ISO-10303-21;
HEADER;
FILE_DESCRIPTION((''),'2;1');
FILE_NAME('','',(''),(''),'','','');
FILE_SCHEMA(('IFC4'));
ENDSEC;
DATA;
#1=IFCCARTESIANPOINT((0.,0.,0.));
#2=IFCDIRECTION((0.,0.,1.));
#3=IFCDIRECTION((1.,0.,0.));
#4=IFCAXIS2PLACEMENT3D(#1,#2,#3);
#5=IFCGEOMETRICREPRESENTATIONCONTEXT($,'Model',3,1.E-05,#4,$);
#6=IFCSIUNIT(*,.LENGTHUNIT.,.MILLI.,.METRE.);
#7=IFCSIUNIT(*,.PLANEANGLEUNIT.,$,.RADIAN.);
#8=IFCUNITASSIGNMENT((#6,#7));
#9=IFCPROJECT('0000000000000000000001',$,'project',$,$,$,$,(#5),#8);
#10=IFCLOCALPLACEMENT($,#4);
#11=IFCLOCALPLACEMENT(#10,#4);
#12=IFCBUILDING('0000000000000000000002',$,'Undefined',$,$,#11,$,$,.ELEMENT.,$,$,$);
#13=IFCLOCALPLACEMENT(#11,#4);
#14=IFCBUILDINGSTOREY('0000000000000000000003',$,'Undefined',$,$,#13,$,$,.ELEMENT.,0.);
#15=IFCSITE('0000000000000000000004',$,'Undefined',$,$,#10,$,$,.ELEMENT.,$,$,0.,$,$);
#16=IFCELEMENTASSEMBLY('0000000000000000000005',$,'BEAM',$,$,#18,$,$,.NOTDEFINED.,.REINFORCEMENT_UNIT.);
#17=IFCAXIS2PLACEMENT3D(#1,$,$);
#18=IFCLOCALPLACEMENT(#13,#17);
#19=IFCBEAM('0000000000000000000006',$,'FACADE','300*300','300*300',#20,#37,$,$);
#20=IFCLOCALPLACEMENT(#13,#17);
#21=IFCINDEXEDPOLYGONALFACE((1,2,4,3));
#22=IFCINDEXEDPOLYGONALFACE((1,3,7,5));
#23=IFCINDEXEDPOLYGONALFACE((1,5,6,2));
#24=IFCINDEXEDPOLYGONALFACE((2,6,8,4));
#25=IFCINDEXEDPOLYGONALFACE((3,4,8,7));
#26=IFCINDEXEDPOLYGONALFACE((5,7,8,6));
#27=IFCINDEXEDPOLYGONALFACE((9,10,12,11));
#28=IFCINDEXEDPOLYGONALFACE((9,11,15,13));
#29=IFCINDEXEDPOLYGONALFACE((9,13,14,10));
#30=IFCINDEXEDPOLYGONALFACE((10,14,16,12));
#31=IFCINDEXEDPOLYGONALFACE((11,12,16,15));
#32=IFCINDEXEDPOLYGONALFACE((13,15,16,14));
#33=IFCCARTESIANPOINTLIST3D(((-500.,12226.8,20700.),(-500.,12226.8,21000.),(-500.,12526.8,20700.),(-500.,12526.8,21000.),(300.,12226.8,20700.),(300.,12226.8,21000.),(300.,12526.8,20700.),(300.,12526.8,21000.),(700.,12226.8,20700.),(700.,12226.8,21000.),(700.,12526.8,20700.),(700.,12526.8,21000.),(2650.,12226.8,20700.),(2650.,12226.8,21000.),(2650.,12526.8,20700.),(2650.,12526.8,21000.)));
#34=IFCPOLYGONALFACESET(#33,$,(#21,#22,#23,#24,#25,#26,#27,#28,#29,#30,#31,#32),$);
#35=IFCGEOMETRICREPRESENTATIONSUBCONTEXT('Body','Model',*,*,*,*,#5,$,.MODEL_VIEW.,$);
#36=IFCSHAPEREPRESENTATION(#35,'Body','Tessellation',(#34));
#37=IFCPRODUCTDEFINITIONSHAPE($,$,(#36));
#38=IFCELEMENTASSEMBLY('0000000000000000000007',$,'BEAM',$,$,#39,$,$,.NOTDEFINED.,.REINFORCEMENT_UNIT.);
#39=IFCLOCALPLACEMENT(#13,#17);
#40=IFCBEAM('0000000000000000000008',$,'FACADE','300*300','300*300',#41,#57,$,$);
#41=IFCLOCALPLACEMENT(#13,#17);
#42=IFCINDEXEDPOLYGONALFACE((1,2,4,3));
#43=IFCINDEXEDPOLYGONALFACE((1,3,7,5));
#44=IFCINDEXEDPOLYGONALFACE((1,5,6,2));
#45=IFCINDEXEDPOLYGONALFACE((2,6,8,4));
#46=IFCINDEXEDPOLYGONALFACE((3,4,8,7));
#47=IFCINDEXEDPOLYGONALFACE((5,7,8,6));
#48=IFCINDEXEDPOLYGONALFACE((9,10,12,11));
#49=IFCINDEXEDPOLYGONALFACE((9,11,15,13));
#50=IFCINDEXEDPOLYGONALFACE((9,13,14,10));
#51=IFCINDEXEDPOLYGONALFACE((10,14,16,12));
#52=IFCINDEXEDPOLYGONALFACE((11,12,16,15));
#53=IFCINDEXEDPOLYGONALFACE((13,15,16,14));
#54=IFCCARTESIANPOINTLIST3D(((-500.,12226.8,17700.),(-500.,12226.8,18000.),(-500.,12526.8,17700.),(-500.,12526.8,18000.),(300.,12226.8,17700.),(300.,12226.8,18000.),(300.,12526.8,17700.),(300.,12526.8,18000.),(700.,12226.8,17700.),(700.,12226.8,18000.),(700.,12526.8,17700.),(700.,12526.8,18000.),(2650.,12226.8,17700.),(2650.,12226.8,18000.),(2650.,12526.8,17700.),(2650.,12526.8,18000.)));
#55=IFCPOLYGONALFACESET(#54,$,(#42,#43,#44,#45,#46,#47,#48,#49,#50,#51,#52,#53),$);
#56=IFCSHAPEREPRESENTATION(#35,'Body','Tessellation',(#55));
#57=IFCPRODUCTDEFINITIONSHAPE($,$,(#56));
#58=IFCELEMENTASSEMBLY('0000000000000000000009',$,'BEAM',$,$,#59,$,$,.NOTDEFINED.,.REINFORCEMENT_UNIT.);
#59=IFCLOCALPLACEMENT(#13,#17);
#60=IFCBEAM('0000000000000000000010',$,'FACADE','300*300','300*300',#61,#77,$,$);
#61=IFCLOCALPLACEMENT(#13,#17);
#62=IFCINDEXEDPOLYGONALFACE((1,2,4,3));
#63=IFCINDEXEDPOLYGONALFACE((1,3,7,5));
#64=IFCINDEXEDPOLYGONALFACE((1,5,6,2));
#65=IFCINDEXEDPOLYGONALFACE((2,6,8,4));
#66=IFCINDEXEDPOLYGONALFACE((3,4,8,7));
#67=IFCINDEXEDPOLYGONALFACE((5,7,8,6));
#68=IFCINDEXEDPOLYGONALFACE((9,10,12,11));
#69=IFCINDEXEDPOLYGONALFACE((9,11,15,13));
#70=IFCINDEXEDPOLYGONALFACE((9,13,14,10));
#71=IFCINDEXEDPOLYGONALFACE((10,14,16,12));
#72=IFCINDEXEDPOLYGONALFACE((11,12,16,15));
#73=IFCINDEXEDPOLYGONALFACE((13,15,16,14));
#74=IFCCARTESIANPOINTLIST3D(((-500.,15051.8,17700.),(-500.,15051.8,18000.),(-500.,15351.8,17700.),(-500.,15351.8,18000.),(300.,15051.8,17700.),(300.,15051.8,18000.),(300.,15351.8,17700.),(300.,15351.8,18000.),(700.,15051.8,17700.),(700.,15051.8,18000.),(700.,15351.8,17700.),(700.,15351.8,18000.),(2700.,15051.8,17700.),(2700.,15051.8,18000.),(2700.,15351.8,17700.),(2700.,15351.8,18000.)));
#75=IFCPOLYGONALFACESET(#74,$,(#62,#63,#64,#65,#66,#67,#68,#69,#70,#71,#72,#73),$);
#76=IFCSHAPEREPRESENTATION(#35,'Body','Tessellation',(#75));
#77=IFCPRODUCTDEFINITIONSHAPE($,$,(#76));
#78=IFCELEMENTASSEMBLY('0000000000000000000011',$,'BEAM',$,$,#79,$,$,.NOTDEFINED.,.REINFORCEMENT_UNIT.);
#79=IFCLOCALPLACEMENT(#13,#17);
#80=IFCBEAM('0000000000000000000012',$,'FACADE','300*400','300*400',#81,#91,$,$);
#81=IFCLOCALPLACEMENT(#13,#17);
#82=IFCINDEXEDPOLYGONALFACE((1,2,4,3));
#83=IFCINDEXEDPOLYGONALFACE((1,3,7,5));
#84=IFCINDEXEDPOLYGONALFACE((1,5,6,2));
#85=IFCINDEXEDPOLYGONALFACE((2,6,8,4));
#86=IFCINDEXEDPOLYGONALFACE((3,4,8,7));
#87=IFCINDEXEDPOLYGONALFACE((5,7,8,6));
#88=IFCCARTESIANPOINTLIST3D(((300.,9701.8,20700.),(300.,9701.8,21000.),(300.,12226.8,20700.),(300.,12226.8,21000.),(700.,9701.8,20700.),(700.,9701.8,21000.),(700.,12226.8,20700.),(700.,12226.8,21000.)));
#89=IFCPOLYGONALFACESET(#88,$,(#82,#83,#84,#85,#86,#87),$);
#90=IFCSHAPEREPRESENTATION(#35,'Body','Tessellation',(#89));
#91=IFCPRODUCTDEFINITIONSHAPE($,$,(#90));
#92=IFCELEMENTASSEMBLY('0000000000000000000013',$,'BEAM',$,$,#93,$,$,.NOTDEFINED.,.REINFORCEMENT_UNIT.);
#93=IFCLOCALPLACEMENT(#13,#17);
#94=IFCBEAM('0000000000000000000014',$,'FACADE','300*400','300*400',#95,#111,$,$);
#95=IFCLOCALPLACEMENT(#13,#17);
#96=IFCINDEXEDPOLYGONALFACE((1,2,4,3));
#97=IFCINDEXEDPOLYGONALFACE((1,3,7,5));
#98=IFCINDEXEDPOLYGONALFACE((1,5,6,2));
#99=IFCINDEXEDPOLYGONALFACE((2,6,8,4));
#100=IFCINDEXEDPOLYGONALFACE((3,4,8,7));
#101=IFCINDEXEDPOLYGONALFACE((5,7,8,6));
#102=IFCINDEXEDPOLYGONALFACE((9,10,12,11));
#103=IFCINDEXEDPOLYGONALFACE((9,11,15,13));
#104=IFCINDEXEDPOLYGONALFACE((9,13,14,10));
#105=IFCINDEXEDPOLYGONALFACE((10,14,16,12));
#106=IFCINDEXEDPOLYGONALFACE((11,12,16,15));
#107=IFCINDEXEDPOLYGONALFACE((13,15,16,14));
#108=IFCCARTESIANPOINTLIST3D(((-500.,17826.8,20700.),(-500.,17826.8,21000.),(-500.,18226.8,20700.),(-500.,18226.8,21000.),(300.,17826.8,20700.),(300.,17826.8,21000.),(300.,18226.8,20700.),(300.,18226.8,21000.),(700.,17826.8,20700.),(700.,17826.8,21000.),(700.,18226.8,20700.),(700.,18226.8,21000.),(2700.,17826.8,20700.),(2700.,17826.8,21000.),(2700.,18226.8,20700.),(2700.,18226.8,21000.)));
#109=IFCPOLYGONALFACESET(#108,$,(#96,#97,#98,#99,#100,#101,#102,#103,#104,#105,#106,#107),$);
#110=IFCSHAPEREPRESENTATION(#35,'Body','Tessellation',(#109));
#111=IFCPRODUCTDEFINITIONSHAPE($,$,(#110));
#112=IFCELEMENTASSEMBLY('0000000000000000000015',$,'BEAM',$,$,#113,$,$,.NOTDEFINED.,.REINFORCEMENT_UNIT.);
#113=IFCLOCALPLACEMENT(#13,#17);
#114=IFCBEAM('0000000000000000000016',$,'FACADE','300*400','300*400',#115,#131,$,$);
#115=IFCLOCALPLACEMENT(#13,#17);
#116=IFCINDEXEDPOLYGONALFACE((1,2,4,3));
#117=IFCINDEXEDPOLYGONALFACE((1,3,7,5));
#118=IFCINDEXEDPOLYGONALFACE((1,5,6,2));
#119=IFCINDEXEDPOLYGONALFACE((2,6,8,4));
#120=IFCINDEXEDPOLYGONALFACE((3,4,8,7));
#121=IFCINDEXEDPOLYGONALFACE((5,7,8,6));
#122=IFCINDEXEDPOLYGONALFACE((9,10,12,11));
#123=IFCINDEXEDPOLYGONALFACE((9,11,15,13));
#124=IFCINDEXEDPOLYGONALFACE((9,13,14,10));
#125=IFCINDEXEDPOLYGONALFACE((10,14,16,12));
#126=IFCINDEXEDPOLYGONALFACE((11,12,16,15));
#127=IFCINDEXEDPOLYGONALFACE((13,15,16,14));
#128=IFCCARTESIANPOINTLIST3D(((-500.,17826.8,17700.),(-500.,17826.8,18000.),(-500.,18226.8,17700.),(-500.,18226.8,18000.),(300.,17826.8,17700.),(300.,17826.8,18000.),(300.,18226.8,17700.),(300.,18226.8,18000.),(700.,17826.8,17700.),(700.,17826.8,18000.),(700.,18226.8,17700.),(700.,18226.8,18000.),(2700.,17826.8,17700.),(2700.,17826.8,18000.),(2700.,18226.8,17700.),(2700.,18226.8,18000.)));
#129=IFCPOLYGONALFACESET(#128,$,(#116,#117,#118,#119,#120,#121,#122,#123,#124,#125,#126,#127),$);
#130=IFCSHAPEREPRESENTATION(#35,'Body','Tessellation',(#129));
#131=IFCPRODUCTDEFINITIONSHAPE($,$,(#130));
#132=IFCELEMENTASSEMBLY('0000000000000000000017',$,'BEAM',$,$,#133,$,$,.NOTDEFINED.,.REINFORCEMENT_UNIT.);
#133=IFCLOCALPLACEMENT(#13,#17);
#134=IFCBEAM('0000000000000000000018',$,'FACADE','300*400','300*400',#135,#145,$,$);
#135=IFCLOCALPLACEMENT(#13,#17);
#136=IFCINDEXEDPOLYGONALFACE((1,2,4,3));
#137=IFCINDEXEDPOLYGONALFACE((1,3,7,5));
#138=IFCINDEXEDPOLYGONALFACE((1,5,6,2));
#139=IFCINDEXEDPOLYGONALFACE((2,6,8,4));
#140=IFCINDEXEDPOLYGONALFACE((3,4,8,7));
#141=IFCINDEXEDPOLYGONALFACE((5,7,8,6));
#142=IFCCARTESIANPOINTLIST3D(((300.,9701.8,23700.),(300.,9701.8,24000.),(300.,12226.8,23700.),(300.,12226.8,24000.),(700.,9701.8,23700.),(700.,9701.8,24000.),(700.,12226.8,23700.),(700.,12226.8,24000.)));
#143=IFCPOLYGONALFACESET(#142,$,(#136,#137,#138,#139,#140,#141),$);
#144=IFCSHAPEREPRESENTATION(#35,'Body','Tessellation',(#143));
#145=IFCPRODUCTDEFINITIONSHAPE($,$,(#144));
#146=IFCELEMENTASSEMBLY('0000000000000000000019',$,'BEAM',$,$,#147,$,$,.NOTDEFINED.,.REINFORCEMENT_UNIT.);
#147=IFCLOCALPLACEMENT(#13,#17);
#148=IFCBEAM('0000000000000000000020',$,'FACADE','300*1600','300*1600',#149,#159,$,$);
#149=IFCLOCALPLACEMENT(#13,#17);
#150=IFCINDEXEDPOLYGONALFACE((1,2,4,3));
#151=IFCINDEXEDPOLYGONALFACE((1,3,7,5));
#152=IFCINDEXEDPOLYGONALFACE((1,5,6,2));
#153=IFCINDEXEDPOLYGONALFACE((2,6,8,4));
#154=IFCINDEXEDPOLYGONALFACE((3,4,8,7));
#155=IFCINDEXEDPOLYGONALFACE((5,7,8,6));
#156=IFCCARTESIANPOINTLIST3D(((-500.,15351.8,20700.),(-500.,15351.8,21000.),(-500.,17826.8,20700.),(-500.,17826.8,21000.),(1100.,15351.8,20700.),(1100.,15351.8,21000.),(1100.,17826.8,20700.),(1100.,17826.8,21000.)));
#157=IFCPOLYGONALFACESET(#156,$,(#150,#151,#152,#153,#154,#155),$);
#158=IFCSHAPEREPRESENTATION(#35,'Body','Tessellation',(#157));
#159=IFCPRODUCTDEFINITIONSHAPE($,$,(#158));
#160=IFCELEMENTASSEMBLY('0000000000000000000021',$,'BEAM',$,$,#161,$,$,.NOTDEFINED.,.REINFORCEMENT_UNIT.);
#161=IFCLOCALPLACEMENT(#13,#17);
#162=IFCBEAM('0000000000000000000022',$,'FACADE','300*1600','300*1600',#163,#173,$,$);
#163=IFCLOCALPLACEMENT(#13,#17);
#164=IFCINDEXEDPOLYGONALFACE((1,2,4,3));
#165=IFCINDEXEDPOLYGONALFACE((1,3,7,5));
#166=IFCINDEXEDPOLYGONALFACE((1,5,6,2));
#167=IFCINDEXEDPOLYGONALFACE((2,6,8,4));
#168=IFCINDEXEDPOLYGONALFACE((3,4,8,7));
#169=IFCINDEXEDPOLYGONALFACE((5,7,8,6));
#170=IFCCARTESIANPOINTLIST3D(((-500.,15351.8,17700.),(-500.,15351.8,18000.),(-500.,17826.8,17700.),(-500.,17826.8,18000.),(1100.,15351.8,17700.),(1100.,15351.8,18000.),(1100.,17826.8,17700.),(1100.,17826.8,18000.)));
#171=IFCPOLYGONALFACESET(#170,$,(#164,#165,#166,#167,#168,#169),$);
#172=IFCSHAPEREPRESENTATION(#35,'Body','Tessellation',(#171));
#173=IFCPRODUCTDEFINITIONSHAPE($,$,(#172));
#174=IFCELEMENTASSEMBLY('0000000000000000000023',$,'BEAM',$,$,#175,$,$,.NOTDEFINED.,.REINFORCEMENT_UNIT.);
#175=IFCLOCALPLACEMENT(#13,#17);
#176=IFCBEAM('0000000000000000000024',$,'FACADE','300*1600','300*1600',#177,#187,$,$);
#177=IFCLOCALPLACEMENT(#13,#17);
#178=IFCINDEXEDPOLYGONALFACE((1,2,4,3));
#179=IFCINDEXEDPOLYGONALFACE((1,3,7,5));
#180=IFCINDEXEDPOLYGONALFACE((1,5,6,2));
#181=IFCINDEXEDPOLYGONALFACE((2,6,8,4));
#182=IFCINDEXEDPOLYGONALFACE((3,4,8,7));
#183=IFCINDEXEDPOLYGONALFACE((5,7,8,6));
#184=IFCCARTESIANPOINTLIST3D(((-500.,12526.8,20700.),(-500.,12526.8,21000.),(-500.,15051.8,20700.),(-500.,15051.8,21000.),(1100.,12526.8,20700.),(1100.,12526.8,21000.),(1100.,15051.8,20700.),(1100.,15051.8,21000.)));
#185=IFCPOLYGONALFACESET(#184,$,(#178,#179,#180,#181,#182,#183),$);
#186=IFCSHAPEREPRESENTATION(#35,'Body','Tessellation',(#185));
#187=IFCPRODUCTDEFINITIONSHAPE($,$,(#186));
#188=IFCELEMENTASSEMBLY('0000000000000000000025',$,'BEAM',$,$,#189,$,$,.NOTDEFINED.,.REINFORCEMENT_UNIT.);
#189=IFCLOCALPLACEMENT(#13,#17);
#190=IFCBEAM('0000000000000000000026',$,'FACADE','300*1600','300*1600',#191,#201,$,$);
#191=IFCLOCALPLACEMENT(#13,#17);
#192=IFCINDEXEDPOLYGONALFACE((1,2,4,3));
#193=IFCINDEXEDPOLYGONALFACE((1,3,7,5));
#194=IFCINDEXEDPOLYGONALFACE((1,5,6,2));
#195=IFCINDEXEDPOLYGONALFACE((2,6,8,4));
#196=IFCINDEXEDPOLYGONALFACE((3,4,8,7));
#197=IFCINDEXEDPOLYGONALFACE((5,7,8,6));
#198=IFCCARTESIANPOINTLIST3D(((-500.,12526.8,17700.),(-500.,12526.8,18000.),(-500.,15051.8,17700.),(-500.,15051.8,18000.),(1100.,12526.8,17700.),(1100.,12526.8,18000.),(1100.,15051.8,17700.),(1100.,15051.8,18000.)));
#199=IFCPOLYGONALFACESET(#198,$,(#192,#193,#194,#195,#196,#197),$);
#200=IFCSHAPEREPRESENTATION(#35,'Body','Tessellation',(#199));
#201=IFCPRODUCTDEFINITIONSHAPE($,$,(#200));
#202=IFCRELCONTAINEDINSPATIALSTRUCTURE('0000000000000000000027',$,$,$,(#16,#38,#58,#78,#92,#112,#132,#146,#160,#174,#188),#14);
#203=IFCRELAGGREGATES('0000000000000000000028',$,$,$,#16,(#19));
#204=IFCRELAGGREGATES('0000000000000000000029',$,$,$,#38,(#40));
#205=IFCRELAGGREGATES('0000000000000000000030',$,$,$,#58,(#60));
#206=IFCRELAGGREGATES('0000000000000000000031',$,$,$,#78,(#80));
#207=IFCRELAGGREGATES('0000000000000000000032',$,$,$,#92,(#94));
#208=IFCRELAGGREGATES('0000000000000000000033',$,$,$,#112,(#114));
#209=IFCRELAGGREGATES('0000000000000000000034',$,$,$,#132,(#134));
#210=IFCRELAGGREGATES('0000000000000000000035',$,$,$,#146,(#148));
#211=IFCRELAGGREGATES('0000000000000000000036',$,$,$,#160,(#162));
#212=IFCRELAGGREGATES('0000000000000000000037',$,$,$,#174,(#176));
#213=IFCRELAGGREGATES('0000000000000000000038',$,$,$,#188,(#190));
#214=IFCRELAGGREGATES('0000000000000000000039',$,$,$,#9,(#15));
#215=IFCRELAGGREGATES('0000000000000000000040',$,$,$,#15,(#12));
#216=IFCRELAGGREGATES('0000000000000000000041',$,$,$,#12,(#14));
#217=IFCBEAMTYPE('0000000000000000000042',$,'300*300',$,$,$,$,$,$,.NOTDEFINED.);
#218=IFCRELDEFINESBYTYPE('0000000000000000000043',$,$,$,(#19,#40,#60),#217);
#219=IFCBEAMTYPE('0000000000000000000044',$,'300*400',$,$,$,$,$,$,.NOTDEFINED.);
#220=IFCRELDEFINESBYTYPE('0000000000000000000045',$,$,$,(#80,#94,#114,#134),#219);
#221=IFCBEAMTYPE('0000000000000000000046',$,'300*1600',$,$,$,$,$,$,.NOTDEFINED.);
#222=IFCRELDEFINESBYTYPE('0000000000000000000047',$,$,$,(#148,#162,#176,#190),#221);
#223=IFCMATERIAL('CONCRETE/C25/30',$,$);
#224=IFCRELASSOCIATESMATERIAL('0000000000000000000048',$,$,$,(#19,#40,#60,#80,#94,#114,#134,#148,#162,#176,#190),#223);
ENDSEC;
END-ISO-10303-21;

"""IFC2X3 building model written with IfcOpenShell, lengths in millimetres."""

from ifc_helpers import new_model, si_unit, frame, origin_with_axes, origin_2d_with_axis, place, context, subcontext, project, spatial, rectangle, extrude, boolean, material, type_object, element, aggregate, save


model = new_model("IFC2X3")

# Units and contexts
model_context = context("Model", 3, precision=1e-05, world=origin_with_axes())
body_context = subcontext(model_context, "Body", "Model", "MODEL_VIEW")
ifc_project = project(units=[si_unit("LENGTHUNIT", "METRE", prefix="MILLI"), si_unit("PLANEANGLEUNIT", "RADIAN")], contexts=[model_context])

# Site, building, storey
site_placement = place(None, origin_with_axes())
site = spatial("IfcSite", under=ifc_project, at=site_placement, Name="Undefined", CompositionType="ELEMENT", RefElevation=0.0)
building_placement = place(site_placement, origin_with_axes())
building = spatial("IfcBuilding", under=site, at=building_placement, Name="Undefined", CompositionType="ELEMENT")
storey_placement = place(building_placement, origin_with_axes())
storey = spatial("IfcBuildingStorey", under=building, at=storey_placement, Name="Undefined", CompositionType="ELEMENT", Elevation=0.0)

# Shared definitions
ifc_material = material(Name="CONCRETE/C25/30")

# Element assemblies, beams
beam_type_1 = type_object("IfcBeamType", Name="300*300", PredefinedType="NOTDEFINED")
assembly_1_placement = place(storey_placement, origin_with_axes())
assembly_1 = element("IfcElementAssembly", 1, at=assembly_1_placement, inside=storey, Name="BEAM", AssemblyPlace="NOTDEFINED", PredefinedType="REINFORCEMENT_UNIT")
beam_1_placement = place(assembly_1_placement, frame((2650.0, 12376.8, 20850.0), z_axis=(0.0, 0.0, 1.0), x_axis=(-1.0, 0.0, 0.0)))
beam_1 = element("IfcBeam", 2, at=beam_1_placement, type_object=beam_type_1, material=ifc_material, Name="FACADE", Description="300*300", ObjectType="300*300", context=body_context, shape_type="CSG", body=[
    boolean("DIFFERENCE", extrude(rectangle(XDim=300.0, YDim=300.0, at=origin_2d_with_axis()), frame((3150.0, 0.0, 0.0), z_axis=(-1.0, 0.0, 0.0), x_axis=(0.0, -1.0, 0.0)), (0.0, 0.0, 1.0), 3150.0), extrude(rectangle(XDim=400.0, YDim=300.0, at=origin_2d_with_axis()), frame((2150.0, 0.0, 150.0), z_axis=(0.0, 0.0, -1.0), x_axis=(1.0, 0.0, 0.0)), (0.0, 0.0, 1.0), 3000.0)),
])
aggregate(assembly_1, [beam_1])
assembly_2_placement = place(storey_placement, origin_with_axes())
assembly_2 = element("IfcElementAssembly", 3, at=assembly_2_placement, inside=storey, Name="BEAM", AssemblyPlace="NOTDEFINED", PredefinedType="REINFORCEMENT_UNIT")
beam_2_placement = place(assembly_2_placement, frame((2650.0, 12376.8, 17850.0), z_axis=(0.0, 0.0, 1.0), x_axis=(-1.0, 0.0, 0.0)))
beam_2 = element("IfcBeam", 4, at=beam_2_placement, type_object=beam_type_1, material=ifc_material, Name="FACADE", Description="300*300", ObjectType="300*300", context=body_context, shape_type="CSG", body=[
    boolean("DIFFERENCE", extrude(rectangle(XDim=300.0, YDim=300.0, at=origin_2d_with_axis()), frame((3150.0, 0.0, 0.0), z_axis=(-1.0, 0.0, 0.0), x_axis=(0.0, -1.0, 0.0)), (0.0, 0.0, 1.0), 3150.0), extrude(rectangle(XDim=400.0, YDim=300.0, at=origin_2d_with_axis()), frame((2150.0, 0.0, 150.0), z_axis=(0.0, 0.0, -1.0), x_axis=(1.0, 0.0, 0.0)), (0.0, 0.0, 1.0), 3000.0)),
])
aggregate(assembly_2, [beam_2])
assembly_3_placement = place(storey_placement, origin_with_axes())
assembly_3 = element("IfcElementAssembly", 5, at=assembly_3_placement, inside=storey, Name="BEAM", AssemblyPlace="NOTDEFINED", PredefinedType="REINFORCEMENT_UNIT")
beam_3_placement = place(assembly_3_placement, frame((2700.0, 15201.8, 17850.0), z_axis=(0.0, 0.0, 1.0), x_axis=(-1.0, 0.0, 0.0)))
beam_3 = element("IfcBeam", 6, at=beam_3_placement, type_object=beam_type_1, material=ifc_material, Name="FACADE", Description="300*300", ObjectType="300*300", context=body_context, shape_type="CSG", body=[
    boolean("DIFFERENCE", extrude(rectangle(XDim=300.0, YDim=300.0, at=origin_2d_with_axis()), frame((3200.0, 0.0, 0.0), z_axis=(-1.0, 0.0, 0.0), x_axis=(0.0, -1.0, 0.0)), (0.0, 0.0, 1.0), 3200.0), extrude(rectangle(XDim=400.0, YDim=300.0, at=origin_2d_with_axis()), frame((2200.0, 0.0, 150.0), z_axis=(0.0, 0.0, -1.0), x_axis=(1.0, 0.0, 0.0)), (0.0, 0.0, 1.0), 3000.0)),
])
aggregate(assembly_3, [beam_3])
beam_type_2 = type_object("IfcBeamType", Name="300*400", PredefinedType="NOTDEFINED")
assembly_4_placement = place(storey_placement, origin_with_axes())
assembly_4 = element("IfcElementAssembly", 7, at=assembly_4_placement, inside=storey, Name="BEAM", AssemblyPlace="NOTDEFINED", PredefinedType="REINFORCEMENT_UNIT")
beam_4_placement = place(assembly_4_placement, frame((500.0, 12226.8, 20850.0), z_axis=(0.0, 0.0, 1.0), x_axis=(0.0, -1.0, 0.0)))
beam_4 = element("IfcBeam", 8, at=beam_4_placement, type_object=beam_type_2, material=ifc_material, Name="FACADE", Description="300*400", ObjectType="300*400", context=body_context, shape_type="SweptSolid", body=[
    extrude(rectangle(XDim=400.0, YDim=300.0, at=origin_2d_with_axis()), frame((2525.0, 0.0, 0.0), z_axis=(-1.0, 0.0, 0.0), x_axis=(0.0, -1.0, 0.0)), (0.0, 0.0, 1.0), 2525.0),
])
aggregate(assembly_4, [beam_4])
assembly_5_placement = place(storey_placement, origin_with_axes())
assembly_5 = element("IfcElementAssembly", 9, at=assembly_5_placement, inside=storey, Name="BEAM", AssemblyPlace="NOTDEFINED", PredefinedType="REINFORCEMENT_UNIT")
beam_5_placement = place(assembly_5_placement, frame((2700.0, 18026.8, 20850.0), z_axis=(0.0, 0.0, 1.0), x_axis=(-1.0, 0.0, 0.0)))
beam_5 = element("IfcBeam", 10, at=beam_5_placement, type_object=beam_type_2, material=ifc_material, Name="FACADE", Description="300*400", ObjectType="300*400", context=body_context, shape_type="CSG", body=[
    boolean("DIFFERENCE", extrude(rectangle(XDim=400.0, YDim=300.0, at=origin_2d_with_axis()), frame((3200.0, 0.0, 0.0), z_axis=(-1.0, 0.0, 0.0), x_axis=(0.0, -1.0, 0.0)), (0.0, 0.0, 1.0), 3200.0), extrude(rectangle(XDim=400.0, YDim=400.0, at=origin_2d_with_axis()), frame((2200.0, 0.0, 150.0), z_axis=(0.0, 0.0, -1.0), x_axis=(1.0, 0.0, 0.0)), (0.0, 0.0, 1.0), 3000.0)),
])
aggregate(assembly_5, [beam_5])
assembly_6_placement = place(storey_placement, origin_with_axes())
assembly_6 = element("IfcElementAssembly", 11, at=assembly_6_placement, inside=storey, Name="BEAM", AssemblyPlace="NOTDEFINED", PredefinedType="REINFORCEMENT_UNIT")
beam_6_placement = place(assembly_6_placement, frame((2700.0, 18026.8, 17850.0), z_axis=(0.0, 0.0, 1.0), x_axis=(-1.0, 0.0, 0.0)))
beam_6 = element("IfcBeam", 12, at=beam_6_placement, type_object=beam_type_2, material=ifc_material, Name="FACADE", Description="300*400", ObjectType="300*400", context=body_context, shape_type="CSG", body=[
    boolean("DIFFERENCE", extrude(rectangle(XDim=400.0, YDim=300.0, at=origin_2d_with_axis()), frame((3200.0, 0.0, 0.0), z_axis=(-1.0, 0.0, 0.0), x_axis=(0.0, -1.0, 0.0)), (0.0, 0.0, 1.0), 3200.0), extrude(rectangle(XDim=400.0, YDim=400.0, at=origin_2d_with_axis()), frame((2200.0, 0.0, 150.0), z_axis=(0.0, 0.0, -1.0), x_axis=(1.0, 0.0, 0.0)), (0.0, 0.0, 1.0), 3000.0)),
])
aggregate(assembly_6, [beam_6])
assembly_7_placement = place(storey_placement, origin_with_axes())
assembly_7 = element("IfcElementAssembly", 13, at=assembly_7_placement, inside=storey, Name="BEAM", AssemblyPlace="NOTDEFINED", PredefinedType="REINFORCEMENT_UNIT")
beam_7_placement = place(assembly_7_placement, frame((500.0, 12226.8, 23850.0), z_axis=(0.0, 0.0, 1.0), x_axis=(0.0, -1.0, 0.0)))
beam_7 = element("IfcBeam", 14, at=beam_7_placement, type_object=beam_type_2, material=ifc_material, Name="FACADE", Description="300*400", ObjectType="300*400", context=body_context, shape_type="SweptSolid", body=[
    extrude(rectangle(XDim=400.0, YDim=300.0, at=origin_2d_with_axis()), frame((2525.0, 0.0, 0.0), z_axis=(-1.0, 0.0, 0.0), x_axis=(0.0, -1.0, 0.0)), (0.0, 0.0, 1.0), 2525.0),
])
aggregate(assembly_7, [beam_7])
assembly_8_placement = place(storey_placement, origin_with_axes())
assembly_8 = element("IfcElementAssembly", 15, at=assembly_8_placement, inside=storey, Name="BEAM", AssemblyPlace="NOTDEFINED", PredefinedType="REINFORCEMENT_UNIT")
beam_type_3 = type_object("IfcBeamType", Name="300*1600", PredefinedType="NOTDEFINED")
beam_8_placement = place(assembly_8_placement, frame((300.0, 15351.8, 20850.0), z_axis=(0.0, 0.0, 1.0), x_axis=(0.0, 1.0, 0.0)))
beam_8 = element("IfcBeam", 16, at=beam_8_placement, type_object=beam_type_3, material=ifc_material, Name="FACADE", Description="300*1600", ObjectType="300*1600", context=body_context, shape_type="SweptSolid", body=[
    extrude(rectangle(XDim=1600.0, YDim=300.0, at=origin_2d_with_axis()), frame((2475.0, 0.0, 0.0), z_axis=(-1.0, 0.0, 0.0), x_axis=(0.0, -1.0, 0.0)), (0.0, 0.0, 1.0), 2475.0),
])
aggregate(assembly_8, [beam_8])
assembly_9_placement = place(storey_placement, origin_with_axes())
assembly_9 = element("IfcElementAssembly", 17, at=assembly_9_placement, inside=storey, Name="BEAM", AssemblyPlace="NOTDEFINED", PredefinedType="REINFORCEMENT_UNIT")
beam_9_placement = place(assembly_9_placement, frame((300.0, 15351.8, 17850.0), z_axis=(0.0, 0.0, 1.0), x_axis=(0.0, 1.0, 0.0)))
beam_9 = element("IfcBeam", 18, at=beam_9_placement, type_object=beam_type_3, material=ifc_material, Name="FACADE", Description="300*1600", ObjectType="300*1600", context=body_context, shape_type="SweptSolid", body=[
    extrude(rectangle(XDim=1600.0, YDim=300.0, at=origin_2d_with_axis()), frame((2475.0, 0.0, 0.0), z_axis=(-1.0, 0.0, 0.0), x_axis=(0.0, -1.0, 0.0)), (0.0, 0.0, 1.0), 2475.0),
])
aggregate(assembly_9, [beam_9])
assembly_10_placement = place(storey_placement, origin_with_axes())
assembly_10 = element("IfcElementAssembly", 19, at=assembly_10_placement, inside=storey, Name="BEAM", AssemblyPlace="NOTDEFINED", PredefinedType="REINFORCEMENT_UNIT")
beam_10_placement = place(assembly_10_placement, frame((300.0, 15051.8, 20850.0), z_axis=(0.0, 0.0, 1.0), x_axis=(0.0, -1.0, 0.0)))
beam_10 = element("IfcBeam", 20, at=beam_10_placement, type_object=beam_type_3, material=ifc_material, Name="FACADE", Description="300*1600", ObjectType="300*1600", context=body_context, shape_type="SweptSolid", body=[
    extrude(rectangle(XDim=1600.0, YDim=300.0, at=origin_2d_with_axis()), frame((2525.0, 0.0, 0.0), z_axis=(-1.0, 0.0, 0.0), x_axis=(0.0, -1.0, 0.0)), (0.0, 0.0, 1.0), 2525.0),
])
aggregate(assembly_10, [beam_10])
assembly_11_placement = place(storey_placement, origin_with_axes())
assembly_11 = element("IfcElementAssembly", 21, at=assembly_11_placement, inside=storey, Name="BEAM", AssemblyPlace="NOTDEFINED", PredefinedType="REINFORCEMENT_UNIT")
beam_11_placement = place(assembly_11_placement, frame((300.0, 15051.8, 17850.0), z_axis=(0.0, 0.0, 1.0), x_axis=(0.0, -1.0, 0.0)))
beam_11 = element("IfcBeam", 22, at=beam_11_placement, type_object=beam_type_3, material=ifc_material, Name="FACADE", Description="300*1600", ObjectType="300*1600", context=body_context, shape_type="SweptSolid", body=[
    extrude(rectangle(XDim=1600.0, YDim=300.0, at=origin_2d_with_axis()), frame((2525.0, 0.0, 0.0), z_axis=(-1.0, 0.0, 0.0), x_axis=(0.0, -1.0, 0.0)), (0.0, 0.0, 1.0), 2525.0),
])
aggregate(assembly_11, [beam_11])

save(model, "model.ifc")
